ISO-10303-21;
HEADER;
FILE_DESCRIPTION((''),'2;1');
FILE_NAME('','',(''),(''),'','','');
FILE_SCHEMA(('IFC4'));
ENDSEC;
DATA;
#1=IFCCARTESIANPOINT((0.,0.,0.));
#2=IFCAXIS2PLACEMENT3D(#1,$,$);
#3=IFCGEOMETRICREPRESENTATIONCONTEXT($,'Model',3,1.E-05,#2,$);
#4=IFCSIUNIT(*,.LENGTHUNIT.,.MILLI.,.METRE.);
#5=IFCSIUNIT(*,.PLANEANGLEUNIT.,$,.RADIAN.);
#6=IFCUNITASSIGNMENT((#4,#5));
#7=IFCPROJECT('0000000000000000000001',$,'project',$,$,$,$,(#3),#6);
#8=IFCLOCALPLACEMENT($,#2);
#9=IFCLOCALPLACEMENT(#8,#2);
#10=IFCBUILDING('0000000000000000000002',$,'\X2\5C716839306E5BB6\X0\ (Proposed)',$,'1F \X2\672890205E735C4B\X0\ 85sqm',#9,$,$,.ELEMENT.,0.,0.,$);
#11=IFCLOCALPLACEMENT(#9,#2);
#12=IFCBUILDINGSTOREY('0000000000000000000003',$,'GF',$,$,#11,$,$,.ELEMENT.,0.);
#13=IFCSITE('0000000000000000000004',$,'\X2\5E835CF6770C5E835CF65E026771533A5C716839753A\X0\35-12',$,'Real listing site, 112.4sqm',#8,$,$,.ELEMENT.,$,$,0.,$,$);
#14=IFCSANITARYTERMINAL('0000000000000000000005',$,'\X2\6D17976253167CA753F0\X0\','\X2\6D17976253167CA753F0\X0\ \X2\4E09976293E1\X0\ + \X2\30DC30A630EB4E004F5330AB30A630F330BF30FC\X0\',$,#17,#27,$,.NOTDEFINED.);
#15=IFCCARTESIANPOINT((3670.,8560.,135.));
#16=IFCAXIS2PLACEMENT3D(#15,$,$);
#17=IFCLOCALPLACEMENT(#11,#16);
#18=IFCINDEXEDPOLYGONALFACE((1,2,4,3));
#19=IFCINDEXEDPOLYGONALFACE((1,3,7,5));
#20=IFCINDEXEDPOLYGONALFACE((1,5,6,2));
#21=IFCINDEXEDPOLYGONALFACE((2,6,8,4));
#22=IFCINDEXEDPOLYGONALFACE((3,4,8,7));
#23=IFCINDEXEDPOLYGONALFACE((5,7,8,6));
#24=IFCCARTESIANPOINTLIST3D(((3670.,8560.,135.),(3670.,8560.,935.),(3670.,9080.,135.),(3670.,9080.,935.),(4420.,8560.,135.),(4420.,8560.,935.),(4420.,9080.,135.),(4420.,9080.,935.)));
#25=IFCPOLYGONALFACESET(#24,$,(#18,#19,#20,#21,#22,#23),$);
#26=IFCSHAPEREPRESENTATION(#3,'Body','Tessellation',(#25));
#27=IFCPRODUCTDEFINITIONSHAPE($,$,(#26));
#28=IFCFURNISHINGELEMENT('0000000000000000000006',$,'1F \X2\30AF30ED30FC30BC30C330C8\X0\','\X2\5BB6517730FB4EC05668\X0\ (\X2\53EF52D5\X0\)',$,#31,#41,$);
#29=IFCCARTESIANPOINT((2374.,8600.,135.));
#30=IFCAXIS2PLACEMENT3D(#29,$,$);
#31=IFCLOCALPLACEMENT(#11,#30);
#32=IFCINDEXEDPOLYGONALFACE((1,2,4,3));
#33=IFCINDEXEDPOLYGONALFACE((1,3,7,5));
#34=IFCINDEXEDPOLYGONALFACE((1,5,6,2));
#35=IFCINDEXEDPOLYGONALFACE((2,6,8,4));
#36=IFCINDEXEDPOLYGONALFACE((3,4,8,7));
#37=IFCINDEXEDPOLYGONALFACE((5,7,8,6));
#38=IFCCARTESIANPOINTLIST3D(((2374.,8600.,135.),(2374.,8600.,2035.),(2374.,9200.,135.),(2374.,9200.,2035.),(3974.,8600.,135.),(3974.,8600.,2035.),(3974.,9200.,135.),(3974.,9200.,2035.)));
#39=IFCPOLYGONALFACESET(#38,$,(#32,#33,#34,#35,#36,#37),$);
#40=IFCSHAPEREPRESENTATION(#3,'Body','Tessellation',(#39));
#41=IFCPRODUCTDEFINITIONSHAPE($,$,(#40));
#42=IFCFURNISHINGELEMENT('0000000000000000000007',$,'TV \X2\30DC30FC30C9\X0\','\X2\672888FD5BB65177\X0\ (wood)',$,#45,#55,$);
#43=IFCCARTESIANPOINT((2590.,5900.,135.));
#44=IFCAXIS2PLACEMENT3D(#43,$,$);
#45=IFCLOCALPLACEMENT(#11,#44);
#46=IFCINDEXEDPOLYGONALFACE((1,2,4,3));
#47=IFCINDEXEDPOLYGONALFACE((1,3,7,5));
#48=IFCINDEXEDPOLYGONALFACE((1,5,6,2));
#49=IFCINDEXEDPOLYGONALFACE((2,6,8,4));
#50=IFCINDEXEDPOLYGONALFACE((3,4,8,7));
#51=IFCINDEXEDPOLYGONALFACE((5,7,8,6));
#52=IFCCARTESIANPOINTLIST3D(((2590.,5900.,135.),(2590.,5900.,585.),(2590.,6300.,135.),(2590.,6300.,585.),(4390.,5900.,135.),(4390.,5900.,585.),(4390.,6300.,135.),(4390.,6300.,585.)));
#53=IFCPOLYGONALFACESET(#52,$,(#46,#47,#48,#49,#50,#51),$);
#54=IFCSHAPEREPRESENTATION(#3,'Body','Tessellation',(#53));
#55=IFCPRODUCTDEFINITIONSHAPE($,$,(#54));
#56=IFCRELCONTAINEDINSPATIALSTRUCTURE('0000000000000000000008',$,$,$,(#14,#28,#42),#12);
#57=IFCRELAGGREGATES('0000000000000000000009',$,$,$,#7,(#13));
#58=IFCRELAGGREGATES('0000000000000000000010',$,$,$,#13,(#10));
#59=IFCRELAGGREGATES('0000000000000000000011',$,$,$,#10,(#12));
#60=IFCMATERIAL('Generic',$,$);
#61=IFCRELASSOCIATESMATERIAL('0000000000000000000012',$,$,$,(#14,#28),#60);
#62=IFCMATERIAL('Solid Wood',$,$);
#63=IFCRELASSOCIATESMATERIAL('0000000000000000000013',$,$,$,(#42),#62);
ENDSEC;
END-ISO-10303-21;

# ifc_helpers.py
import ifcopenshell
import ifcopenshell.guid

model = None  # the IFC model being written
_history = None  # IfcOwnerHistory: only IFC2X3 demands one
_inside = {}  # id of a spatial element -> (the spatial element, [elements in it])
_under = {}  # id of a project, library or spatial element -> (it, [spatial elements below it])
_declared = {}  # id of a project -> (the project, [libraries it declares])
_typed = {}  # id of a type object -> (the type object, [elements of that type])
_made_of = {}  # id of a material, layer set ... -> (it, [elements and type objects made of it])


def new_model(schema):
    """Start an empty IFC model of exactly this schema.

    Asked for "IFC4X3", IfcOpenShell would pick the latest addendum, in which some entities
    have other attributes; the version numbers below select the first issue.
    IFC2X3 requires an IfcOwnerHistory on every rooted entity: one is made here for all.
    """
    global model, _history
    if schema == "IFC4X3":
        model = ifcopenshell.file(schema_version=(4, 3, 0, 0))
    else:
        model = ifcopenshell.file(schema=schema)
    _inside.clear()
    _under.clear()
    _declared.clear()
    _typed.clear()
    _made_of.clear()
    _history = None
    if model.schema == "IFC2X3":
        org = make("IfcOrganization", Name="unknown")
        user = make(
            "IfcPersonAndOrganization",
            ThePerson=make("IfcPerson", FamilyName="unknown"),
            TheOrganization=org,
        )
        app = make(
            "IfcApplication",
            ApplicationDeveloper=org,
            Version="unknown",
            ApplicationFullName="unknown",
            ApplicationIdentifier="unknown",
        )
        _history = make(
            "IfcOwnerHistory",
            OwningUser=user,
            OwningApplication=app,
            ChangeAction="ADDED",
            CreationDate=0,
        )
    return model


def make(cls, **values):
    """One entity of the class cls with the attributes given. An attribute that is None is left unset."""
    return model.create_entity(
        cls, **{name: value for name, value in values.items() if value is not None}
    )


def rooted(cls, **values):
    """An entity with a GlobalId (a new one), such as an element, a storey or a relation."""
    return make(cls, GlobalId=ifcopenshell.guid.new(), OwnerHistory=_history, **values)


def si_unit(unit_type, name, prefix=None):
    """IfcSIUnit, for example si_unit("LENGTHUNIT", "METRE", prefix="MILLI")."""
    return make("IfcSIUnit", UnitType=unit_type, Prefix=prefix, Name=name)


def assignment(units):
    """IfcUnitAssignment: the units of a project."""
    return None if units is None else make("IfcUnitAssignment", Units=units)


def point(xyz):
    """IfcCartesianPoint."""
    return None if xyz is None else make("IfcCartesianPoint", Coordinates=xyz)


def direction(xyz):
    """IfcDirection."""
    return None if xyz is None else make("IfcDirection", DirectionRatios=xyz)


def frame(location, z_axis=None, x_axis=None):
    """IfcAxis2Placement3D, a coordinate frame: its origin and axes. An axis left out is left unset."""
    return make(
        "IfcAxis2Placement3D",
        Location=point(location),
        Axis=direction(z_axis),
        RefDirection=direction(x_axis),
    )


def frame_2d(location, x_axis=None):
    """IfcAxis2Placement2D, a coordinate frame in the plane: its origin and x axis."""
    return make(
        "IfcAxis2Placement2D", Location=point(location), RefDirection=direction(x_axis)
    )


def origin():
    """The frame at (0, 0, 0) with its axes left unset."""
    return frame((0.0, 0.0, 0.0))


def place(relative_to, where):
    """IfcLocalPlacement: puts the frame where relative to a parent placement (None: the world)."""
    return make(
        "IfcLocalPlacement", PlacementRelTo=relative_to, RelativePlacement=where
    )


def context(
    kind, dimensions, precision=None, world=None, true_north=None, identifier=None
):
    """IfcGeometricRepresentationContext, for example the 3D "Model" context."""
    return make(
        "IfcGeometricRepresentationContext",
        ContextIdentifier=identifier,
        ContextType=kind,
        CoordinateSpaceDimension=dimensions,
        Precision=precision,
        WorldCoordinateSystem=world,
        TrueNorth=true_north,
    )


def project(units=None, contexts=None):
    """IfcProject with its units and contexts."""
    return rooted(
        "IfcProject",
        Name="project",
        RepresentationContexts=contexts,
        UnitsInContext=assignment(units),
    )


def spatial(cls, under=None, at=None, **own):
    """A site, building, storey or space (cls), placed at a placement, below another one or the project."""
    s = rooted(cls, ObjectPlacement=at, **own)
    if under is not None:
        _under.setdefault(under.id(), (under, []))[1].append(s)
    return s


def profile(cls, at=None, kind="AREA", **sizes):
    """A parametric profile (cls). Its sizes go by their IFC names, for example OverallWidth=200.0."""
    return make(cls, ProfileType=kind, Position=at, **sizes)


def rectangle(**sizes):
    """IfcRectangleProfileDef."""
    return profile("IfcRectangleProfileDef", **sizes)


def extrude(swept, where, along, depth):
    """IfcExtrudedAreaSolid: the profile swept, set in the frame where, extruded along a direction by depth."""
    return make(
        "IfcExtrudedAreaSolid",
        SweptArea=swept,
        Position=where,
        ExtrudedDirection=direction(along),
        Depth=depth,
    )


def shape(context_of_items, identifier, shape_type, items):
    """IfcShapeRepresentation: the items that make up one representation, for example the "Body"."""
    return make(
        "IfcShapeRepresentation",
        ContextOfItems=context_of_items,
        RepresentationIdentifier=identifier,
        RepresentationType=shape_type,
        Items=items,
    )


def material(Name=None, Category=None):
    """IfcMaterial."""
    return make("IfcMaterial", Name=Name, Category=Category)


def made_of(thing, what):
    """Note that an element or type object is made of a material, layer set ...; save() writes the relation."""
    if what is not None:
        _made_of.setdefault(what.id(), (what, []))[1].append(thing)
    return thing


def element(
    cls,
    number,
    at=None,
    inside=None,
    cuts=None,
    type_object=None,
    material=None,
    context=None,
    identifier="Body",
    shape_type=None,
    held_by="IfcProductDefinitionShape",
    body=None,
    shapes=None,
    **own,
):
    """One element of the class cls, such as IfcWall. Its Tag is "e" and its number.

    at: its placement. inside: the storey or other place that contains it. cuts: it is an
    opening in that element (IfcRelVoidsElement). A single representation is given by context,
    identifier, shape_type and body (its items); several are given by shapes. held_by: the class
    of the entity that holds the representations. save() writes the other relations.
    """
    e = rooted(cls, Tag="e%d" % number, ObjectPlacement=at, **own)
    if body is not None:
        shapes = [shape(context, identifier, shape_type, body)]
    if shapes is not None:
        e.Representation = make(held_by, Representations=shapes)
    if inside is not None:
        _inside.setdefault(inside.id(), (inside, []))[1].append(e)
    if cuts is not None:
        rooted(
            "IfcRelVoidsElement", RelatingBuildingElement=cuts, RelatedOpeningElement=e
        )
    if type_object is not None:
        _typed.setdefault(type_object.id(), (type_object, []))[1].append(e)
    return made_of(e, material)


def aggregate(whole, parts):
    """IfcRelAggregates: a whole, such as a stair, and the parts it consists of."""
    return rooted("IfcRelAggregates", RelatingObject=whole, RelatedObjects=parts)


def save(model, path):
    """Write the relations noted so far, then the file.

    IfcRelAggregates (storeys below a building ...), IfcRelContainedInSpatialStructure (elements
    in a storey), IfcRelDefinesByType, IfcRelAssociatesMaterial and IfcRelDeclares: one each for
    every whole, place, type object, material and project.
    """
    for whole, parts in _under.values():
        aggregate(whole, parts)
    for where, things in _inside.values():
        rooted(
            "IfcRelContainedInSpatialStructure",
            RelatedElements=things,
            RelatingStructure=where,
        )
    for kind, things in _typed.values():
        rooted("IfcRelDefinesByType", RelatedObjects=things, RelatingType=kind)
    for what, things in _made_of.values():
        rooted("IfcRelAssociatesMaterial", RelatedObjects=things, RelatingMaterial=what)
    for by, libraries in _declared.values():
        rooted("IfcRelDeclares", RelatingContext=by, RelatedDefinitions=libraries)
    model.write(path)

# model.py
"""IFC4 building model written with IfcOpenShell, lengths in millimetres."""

from ifc_helpers import new_model, si_unit, frame, frame_2d, origin, place, context, project, spatial, rectangle, extrude, material, element, save


model = new_model("IFC4")

# Units and contexts
model_context = context("Model", 3, precision=1e-05, world=origin())
ifc_project = project(units=[si_unit("LENGTHUNIT", "METRE", prefix="MILLI"), si_unit("PLANEANGLEUNIT", "RADIAN")], contexts=[model_context])

# Site, building, storey
site_placement = place(None, origin())
site = spatial("IfcSite", under=ifc_project, at=site_placement, Name="広島県広島市東区山根町35-12", ObjectType="Real listing site, 112.4sqm", CompositionType="ELEMENT", RefElevation=0.0)
building_placement = place(site_placement, origin())
building = spatial("IfcBuilding", under=site, at=building_placement, Name="山根の家 (Proposed)", ObjectType="1F 木造平屋 85sqm", CompositionType="ELEMENT", ElevationOfRefHeight=0.0, ElevationOfTerrain=0.0)
storey_placement = place(building_placement, origin())
storey = spatial("IfcBuildingStorey", under=building, at=storey_placement, Name="GF", CompositionType="ELEMENT", Elevation=0.0)

# Shared definitions
ifc_material_1 = material(Name="Solid Wood")

# Shared definitions
ifc_material_2 = material(Name="Generic")

# Sanitary terminal
sanitary_terminal_1_placement = place(storey_placement, frame((3670.0, 8560.0, 135.0)))
element("IfcSanitaryTerminal", 1, at=sanitary_terminal_1_placement, inside=storey, material=ifc_material_2, Name="洗面化粧台", Description="洗面化粧台 三面鏡 + ボウル一体カウンター", PredefinedType="NOTDEFINED", context=model_context, shape_type="SweptSolid", body=[
    extrude(rectangle(XDim=750.0, YDim=520.0, at=frame_2d((375.0, 260.0))), frame((3670.0, 8560.0, 135.0)), (0.0, 0.0, 1.0), 800.0),
])

# Furnishing elements
furnishing_1_placement = place(storey_placement, frame((2374.0, 8600.0, 135.0)))
element("IfcFurnishingElement", 2, at=furnishing_1_placement, inside=storey, material=ifc_material_2, Name="1F クローゼット", Description="家具・什器 (可動)", context=model_context, shape_type="SweptSolid", body=[
    extrude(rectangle(XDim=1600.0, YDim=600.0, at=frame_2d((800.0, 300.0))), frame((2374.0, 8600.0, 135.0)), (0.0, 0.0, 1.0), 1900.0),
])
furnishing_2_placement = place(storey_placement, frame((2590.0, 5900.0, 135.0)))
element("IfcFurnishingElement", 3, at=furnishing_2_placement, inside=storey, material=ifc_material_1, Name="TV ボード", Description="木製家具 (wood)", context=model_context, shape_type="SweptSolid", body=[
    extrude(rectangle(XDim=1800.0, YDim=400.0, at=frame_2d((900.0, 200.0))), frame((2590.0, 5900.0, 135.0)), (0.0, 0.0, 1.0), 450.0),
])

save(model, "model.ifc")
